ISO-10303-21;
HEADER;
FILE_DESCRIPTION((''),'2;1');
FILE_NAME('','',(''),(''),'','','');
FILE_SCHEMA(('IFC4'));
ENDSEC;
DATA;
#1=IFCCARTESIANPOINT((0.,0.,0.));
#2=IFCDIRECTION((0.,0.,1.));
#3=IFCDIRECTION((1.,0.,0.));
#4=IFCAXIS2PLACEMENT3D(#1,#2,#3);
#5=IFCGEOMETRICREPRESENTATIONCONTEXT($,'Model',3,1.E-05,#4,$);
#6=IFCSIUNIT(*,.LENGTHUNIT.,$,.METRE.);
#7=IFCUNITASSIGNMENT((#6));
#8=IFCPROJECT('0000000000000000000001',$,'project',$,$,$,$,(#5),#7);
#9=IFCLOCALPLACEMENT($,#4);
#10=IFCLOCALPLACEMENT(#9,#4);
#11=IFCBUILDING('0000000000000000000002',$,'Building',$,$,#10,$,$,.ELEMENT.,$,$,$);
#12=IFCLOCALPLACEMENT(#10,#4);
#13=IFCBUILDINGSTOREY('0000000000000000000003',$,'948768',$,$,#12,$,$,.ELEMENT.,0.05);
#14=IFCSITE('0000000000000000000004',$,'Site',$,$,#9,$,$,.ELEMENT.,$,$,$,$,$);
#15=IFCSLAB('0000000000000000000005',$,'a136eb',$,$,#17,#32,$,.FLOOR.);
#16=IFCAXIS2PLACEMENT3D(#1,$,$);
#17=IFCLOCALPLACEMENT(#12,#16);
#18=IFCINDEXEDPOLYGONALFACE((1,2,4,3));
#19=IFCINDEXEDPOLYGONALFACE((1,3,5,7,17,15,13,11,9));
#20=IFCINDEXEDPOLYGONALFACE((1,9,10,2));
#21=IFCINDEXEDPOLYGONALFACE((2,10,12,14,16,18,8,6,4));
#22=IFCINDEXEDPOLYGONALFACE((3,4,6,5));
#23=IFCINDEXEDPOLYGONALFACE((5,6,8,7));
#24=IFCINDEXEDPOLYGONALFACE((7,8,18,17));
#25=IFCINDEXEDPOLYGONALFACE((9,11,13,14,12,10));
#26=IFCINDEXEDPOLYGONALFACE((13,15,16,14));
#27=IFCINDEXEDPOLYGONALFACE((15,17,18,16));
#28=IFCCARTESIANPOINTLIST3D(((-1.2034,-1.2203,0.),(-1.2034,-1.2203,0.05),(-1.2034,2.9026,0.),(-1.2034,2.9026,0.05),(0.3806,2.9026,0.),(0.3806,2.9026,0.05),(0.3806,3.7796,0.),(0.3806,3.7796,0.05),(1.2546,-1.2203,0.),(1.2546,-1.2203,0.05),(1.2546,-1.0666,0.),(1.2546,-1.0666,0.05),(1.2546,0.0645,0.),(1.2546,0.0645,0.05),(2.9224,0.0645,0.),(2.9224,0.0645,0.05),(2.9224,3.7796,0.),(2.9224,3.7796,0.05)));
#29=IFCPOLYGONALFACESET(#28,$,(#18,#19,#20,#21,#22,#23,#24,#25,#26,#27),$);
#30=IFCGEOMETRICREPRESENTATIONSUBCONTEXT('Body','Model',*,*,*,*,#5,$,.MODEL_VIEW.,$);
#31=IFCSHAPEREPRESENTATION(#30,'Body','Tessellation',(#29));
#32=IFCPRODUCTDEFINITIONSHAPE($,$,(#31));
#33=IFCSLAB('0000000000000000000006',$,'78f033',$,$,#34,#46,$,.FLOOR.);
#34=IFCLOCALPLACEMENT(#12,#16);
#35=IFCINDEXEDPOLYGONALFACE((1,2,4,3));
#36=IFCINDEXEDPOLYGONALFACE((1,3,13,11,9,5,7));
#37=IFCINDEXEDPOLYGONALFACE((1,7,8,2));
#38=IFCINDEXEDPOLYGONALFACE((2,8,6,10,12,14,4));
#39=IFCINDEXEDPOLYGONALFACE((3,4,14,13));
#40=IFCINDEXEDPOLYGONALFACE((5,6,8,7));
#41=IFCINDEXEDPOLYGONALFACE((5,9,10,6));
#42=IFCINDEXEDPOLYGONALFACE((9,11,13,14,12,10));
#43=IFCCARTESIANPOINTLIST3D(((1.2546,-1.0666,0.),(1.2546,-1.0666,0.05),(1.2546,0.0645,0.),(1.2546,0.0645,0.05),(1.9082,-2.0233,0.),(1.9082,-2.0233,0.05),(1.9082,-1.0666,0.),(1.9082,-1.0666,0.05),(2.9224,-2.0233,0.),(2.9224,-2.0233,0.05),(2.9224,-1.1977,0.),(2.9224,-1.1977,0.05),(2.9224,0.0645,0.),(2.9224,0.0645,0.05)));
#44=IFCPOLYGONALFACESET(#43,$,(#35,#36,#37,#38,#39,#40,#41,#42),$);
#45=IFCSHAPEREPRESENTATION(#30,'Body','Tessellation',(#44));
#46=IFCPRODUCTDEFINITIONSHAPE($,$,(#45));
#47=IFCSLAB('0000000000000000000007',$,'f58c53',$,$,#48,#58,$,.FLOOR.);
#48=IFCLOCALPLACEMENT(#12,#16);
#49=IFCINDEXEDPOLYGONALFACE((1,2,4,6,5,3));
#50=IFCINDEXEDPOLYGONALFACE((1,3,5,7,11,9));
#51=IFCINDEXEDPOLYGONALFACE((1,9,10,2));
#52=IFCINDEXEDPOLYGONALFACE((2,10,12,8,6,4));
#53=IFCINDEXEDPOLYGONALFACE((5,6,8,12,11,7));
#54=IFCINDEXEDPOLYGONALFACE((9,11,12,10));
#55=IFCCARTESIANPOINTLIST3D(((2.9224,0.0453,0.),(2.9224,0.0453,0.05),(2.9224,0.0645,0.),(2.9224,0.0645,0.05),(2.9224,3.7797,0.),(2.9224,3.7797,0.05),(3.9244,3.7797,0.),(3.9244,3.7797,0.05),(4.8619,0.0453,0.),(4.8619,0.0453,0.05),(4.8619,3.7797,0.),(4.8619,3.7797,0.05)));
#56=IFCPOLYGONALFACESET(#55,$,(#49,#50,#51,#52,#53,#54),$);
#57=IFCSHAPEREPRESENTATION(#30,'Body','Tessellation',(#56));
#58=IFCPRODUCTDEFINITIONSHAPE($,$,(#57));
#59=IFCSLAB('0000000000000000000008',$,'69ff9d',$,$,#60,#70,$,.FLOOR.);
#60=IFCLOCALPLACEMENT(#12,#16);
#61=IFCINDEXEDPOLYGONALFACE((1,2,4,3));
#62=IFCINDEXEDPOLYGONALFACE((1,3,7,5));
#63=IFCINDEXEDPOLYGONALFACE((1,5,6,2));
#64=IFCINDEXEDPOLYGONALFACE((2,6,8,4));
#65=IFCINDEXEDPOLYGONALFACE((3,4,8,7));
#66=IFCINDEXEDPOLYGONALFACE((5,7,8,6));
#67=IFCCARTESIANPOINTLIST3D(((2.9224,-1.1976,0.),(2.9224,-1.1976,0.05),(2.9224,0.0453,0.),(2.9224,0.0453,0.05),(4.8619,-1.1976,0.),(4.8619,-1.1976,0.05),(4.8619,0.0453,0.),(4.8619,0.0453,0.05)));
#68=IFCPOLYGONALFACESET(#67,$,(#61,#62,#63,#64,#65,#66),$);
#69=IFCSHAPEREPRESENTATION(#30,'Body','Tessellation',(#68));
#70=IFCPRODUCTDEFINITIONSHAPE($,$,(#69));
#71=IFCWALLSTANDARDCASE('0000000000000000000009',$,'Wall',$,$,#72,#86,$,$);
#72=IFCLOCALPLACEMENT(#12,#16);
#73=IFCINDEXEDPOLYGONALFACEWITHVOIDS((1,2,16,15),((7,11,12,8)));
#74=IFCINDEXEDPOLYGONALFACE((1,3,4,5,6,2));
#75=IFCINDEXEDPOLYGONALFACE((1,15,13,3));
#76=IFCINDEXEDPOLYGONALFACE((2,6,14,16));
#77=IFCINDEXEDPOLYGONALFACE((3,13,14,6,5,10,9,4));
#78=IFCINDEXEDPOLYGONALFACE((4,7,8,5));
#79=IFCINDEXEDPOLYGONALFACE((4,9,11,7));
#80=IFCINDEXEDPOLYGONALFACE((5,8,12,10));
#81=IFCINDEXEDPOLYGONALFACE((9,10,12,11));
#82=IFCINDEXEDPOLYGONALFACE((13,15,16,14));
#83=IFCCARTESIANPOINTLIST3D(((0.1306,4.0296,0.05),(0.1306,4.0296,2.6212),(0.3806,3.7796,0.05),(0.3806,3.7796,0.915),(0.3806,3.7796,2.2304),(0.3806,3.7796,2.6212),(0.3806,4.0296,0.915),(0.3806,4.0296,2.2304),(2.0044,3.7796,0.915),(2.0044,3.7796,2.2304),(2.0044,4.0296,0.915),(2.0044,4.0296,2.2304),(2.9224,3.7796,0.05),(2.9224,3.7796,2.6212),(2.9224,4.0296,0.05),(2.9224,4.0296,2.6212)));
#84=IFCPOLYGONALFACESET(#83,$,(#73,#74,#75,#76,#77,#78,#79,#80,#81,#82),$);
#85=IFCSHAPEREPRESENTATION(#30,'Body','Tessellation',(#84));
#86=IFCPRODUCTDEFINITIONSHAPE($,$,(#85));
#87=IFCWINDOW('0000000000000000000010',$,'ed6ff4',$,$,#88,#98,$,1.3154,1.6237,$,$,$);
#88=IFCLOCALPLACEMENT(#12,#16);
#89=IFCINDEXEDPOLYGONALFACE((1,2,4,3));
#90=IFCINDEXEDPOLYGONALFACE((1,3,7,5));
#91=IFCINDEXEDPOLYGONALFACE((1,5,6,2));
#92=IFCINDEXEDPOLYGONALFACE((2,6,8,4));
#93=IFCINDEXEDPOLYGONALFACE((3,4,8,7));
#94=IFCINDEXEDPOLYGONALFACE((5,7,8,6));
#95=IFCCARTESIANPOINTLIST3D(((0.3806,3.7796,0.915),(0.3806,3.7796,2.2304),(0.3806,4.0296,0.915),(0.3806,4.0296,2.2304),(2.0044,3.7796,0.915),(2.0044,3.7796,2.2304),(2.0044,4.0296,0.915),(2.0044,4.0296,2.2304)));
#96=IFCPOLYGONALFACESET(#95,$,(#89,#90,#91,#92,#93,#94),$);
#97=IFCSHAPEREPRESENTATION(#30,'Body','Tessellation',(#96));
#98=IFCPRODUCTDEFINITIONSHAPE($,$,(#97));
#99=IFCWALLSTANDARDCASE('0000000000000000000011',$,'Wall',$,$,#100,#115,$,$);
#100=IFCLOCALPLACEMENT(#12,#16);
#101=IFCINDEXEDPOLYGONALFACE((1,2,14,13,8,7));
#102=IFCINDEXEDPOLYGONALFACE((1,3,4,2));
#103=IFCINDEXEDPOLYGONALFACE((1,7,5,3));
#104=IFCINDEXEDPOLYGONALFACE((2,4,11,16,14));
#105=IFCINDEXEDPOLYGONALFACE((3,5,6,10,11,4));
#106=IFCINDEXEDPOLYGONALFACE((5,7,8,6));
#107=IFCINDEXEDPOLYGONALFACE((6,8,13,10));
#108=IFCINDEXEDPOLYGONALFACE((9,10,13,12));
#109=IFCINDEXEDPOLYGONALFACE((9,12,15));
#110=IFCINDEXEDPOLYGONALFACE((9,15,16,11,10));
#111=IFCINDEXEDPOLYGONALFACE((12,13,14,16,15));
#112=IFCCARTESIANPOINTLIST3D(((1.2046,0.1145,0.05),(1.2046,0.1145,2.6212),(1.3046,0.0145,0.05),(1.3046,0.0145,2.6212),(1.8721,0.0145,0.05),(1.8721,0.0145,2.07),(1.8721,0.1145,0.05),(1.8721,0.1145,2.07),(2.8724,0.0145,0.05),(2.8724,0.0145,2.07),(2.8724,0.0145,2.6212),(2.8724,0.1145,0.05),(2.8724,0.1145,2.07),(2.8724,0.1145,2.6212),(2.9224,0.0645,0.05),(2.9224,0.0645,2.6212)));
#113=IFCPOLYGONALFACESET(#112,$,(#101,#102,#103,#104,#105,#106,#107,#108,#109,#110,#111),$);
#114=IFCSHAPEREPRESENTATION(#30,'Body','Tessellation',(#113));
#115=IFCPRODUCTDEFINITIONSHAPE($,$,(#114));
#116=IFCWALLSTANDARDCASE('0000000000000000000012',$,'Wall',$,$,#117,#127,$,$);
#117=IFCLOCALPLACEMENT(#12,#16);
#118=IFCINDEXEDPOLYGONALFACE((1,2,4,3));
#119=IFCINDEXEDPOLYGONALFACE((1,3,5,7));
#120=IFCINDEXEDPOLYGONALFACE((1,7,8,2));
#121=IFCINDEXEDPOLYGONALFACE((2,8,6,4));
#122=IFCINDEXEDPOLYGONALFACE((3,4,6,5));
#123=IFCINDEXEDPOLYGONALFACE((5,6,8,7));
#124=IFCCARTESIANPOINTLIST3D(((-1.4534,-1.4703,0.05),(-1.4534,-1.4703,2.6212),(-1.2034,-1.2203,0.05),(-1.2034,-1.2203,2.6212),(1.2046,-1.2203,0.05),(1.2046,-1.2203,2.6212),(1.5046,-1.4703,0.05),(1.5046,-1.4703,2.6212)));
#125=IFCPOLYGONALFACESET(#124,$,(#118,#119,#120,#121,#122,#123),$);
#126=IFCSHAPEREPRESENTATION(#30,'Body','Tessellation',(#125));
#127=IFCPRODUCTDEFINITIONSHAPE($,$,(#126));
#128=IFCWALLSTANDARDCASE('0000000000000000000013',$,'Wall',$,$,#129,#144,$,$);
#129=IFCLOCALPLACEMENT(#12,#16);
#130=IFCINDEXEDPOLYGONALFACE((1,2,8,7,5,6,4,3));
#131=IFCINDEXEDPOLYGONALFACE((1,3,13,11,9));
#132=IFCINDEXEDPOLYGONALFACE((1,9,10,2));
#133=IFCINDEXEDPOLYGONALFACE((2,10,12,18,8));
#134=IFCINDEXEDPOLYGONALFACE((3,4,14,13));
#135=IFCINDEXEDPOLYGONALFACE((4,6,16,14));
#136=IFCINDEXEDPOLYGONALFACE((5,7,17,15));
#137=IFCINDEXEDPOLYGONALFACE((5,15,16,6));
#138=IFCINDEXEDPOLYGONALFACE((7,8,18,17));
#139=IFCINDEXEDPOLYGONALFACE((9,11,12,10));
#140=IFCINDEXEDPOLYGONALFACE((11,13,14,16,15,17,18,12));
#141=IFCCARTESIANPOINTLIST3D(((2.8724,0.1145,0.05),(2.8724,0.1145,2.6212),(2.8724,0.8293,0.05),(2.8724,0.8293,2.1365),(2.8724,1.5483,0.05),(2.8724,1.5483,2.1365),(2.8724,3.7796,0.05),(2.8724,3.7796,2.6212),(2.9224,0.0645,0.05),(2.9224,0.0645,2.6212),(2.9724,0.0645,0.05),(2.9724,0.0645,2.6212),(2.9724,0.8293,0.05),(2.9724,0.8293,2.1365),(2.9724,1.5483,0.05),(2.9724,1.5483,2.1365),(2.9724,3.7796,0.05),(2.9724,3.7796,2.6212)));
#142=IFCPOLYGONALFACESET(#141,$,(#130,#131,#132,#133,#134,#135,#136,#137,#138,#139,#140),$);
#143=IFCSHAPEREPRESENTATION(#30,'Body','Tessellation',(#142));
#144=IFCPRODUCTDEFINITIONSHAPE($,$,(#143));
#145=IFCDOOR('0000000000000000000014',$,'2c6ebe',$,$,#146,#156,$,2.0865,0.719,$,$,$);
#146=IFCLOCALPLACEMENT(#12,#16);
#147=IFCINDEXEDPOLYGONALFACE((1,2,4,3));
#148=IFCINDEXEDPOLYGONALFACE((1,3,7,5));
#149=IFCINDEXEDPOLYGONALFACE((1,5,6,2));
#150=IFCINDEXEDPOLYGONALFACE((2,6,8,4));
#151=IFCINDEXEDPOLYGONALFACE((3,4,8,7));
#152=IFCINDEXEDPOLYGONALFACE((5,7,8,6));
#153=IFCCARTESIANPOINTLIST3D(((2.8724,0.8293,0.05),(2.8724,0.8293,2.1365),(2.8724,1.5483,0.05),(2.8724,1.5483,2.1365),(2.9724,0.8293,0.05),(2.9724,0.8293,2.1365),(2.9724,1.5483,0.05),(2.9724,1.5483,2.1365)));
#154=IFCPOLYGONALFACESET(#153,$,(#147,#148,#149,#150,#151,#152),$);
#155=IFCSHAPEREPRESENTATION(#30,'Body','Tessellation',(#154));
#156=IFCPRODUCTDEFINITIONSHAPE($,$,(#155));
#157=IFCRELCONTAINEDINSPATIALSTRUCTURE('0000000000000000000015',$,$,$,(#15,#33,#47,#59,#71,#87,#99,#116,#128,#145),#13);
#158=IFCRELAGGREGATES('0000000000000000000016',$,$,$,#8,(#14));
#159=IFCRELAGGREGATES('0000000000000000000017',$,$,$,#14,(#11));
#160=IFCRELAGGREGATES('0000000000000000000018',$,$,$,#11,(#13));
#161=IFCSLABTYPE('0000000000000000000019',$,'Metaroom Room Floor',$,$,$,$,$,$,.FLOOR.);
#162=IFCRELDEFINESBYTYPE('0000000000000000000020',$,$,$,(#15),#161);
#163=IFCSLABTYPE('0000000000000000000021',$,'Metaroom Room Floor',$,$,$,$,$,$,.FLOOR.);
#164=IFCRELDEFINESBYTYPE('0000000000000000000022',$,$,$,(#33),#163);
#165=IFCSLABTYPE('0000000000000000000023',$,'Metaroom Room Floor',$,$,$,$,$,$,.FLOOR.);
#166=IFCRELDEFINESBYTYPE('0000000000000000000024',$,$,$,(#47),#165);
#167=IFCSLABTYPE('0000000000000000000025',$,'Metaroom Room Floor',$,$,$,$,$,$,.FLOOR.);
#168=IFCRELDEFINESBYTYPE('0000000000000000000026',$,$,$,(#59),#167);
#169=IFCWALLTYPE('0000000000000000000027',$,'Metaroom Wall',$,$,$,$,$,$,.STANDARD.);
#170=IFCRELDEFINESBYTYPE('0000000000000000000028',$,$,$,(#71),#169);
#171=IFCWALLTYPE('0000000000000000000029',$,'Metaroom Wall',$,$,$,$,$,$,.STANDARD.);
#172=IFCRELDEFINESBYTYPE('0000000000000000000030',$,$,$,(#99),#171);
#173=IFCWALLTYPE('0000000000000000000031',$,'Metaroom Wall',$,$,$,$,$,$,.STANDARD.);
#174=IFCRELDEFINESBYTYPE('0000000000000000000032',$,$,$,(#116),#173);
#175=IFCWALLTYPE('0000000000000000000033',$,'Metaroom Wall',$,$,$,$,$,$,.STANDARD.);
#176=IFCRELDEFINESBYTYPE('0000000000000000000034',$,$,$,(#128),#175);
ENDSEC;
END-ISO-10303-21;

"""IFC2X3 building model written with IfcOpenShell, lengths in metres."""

from ifc_helpers import new_model, si_unit, frame, origin_with_axes, place, context, subcontext, project, spatial, polyline, outline, extrude, type_object, element, fill, save


model = new_model("IFC2X3")

# Units and contexts
model_context = context("Model", 3, precision=1e-05, world=origin_with_axes())
body_context = subcontext(model_context, "Body", "Model", "MODEL_VIEW")
ifc_project = project(units=[si_unit("LENGTHUNIT", "METRE")], contexts=[model_context])

# Site, building, storey
site_placement = place(None, origin_with_axes())
site = spatial("IfcSite", under=ifc_project, at=site_placement, Name="Site", CompositionType="ELEMENT")
building_placement = place(site_placement, origin_with_axes())
building = spatial("IfcBuilding", under=site, at=building_placement, Name="Building", CompositionType="ELEMENT")
storey_placement = place(building_placement, frame((0.0, 0.0, 0.0), z_axis=(0.0, 0.0, 1.0), x_axis=(1.0, 0.0, 0.0)))
storey = spatial("IfcBuildingStorey", under=building, at=storey_placement, Name="948768", CompositionType="ELEMENT", Elevation=0.05)

# Slabs
slab_type_1 = type_object("IfcSlabType", Name="Metaroom Room Floor", PredefinedType="FLOOR")
slab_1_placement = place(storey_placement, frame((2.9224, 3.7796, 0.05), z_axis=(0.0, 0.0, 1.0), x_axis=(1.0, 0.0, 0.0)))
element("IfcSlab", 1, at=slab_1_placement, inside=storey, type_object=slab_type_1, Name="a136eb", PredefinedType="FLOOR", context=body_context, shape_type="SweptSolid", body=[
    extrude(outline(polyline([(0.0, 0.0), (0.0, -3.7152), (-1.6678, -3.7152), (-1.6678, -4.8463), (-1.6678, -5.0), (-4.1257, -5.0), (-4.1257, -0.877), (-2.5417, -0.877), (-2.5417, 0.0), (0.0, 0.0)])), origin_with_axes(), (0.0, 0.0, -1.0), 0.05),
])
slab_type_2 = type_object("IfcSlabType", Name="Metaroom Room Floor", PredefinedType="FLOOR")
slab_2_placement = place(storey_placement, frame((1.2546, -1.0666, 0.05), z_axis=(0.0, 0.0, 1.0), x_axis=(1.0, 0.0, 0.0)))
element("IfcSlab", 2, at=slab_2_placement, inside=storey, type_object=slab_type_2, Name="78f033", PredefinedType="FLOOR", context=body_context, shape_type="SweptSolid", body=[
    extrude(outline(polyline([(0.0, 0.0), (0.0, 1.1311), (1.6678, 1.1311), (1.6678, -0.1311), (1.6678, -0.9567), (0.6536, -0.9567), (0.6536, 0.0), (0.0, 0.0)])), origin_with_axes(), (0.0, 0.0, -1.0), 0.05),
])
slab_type_3 = type_object("IfcSlabType", Name="Metaroom Room Floor", PredefinedType="FLOOR")
slab_3_placement = place(storey_placement, frame((4.8619, 3.7797, 0.05), z_axis=(0.0, 0.0, 1.0), x_axis=(1.0, 0.0, 0.0)))
element("IfcSlab", 3, at=slab_3_placement, inside=storey, type_object=slab_type_3, Name="f58c53", PredefinedType="FLOOR", context=body_context, shape_type="SweptSolid", body=[
    extrude(outline(polyline([(0.0, 0.0), (-0.9375, 0.0), (-1.9395, 0.0), (-1.9395, -3.7152), (-1.9395, -3.7344), (0.0, -3.7344), (0.0, 0.0)])), origin_with_axes(), (0.0, 0.0, -1.0), 0.05),
])
slab_type_4 = type_object("IfcSlabType", Name="Metaroom Room Floor", PredefinedType="FLOOR")
slab_4_placement = place(storey_placement, frame((2.9224, -1.1976, 0.05), z_axis=(0.0, 0.0, 1.0), x_axis=(1.0, 0.0, 0.0)))
element("IfcSlab", 4, at=slab_4_placement, inside=storey, type_object=slab_type_4, Name="69ff9d", PredefinedType="FLOOR", context=body_context, shape_type="SweptSolid", body=[
    extrude(outline(polyline([(0.0, 0.0), (1.9395, 0.0), (1.9395, 1.2429), (0.0, 1.2429), (0.0, 0.0)])), origin_with_axes(), (0.0, 0.0, -1.0), 0.05),
])

# Wall, opening, window
wall_type_1 = type_object("IfcWallType", Name="Metaroom Wall", PredefinedType="STANDARD")
wall_1_placement = place(storey_placement, frame((0.1306, 4.0296, 0.05), z_axis=(0.0, 0.0, 1.0), x_axis=(1.0, 0.0, 0.0)))
wall_1 = element("IfcWallStandardCase", 5, at=wall_1_placement, inside=storey, type_object=wall_type_1, Name="Wall", context=body_context, shape_type="SweptSolid", body=[
    extrude(outline(polyline([(0.0, 0.0), (2.7917, 0.0), (2.7917, -0.25), (2.7417, -0.25), (0.25, -0.25), (0.0, 0.0)])), origin_with_axes(), (0.0, 0.0, 1.0), 2.5712),
])
opening_1_placement = place(wall_1_placement, frame((0.25, -0.25, 0.865), z_axis=(0.0, 0.0, 1.0), x_axis=(1.0, 0.0, 0.0)))
opening_1 = element("IfcOpeningElement", 6, at=opening_1_placement, cuts=wall_1, ObjectType="OPENING", context=body_context, shape_type="SweptSolid", body=[
    extrude(outline(polyline([(0.0, 0.0), (1.6237, 0.0), (1.6237, 1.3154), (0.0, 1.3154), (0.0, 0.0)])), frame((0.0, 0.0, 0.0), z_axis=(0.0, -1.0, 0.0), x_axis=(1.0, 0.0, 0.0)), (0.0, 0.0, -1.0), 0.2501),
])
window_1_placement = place(opening_1_placement, origin_with_axes())
window_1 = element("IfcWindow", 7, at=window_1_placement, inside=storey, Name="ed6ff4", OverallHeight=1.3154, OverallWidth=1.6237, context=body_context, shape_type="SweptSolid", body=[
    extrude(outline(polyline([(0.0, 0.0), (-1.6237, 0.0), (-1.6237, 1.3154), (0.0, 1.3154), (0.0, 0.0)])), frame((0.0, 0.25, 0.0), z_axis=(0.0, 1.0, 0.0), x_axis=(-1.0, 0.0, 0.0)), (0.0, 0.0, -1.0), 0.25),
])
fill(opening_1, window_1)

# Wall, opening
wall_type_2 = type_object("IfcWallType", Name="Metaroom Wall", PredefinedType="STANDARD")
wall_2_placement = place(storey_placement, frame((2.8724, 0.1145, 0.05), z_axis=(0.0, 0.0, 1.0), x_axis=(1.0, 0.0, 0.0)))
wall_2 = element("IfcWallStandardCase", 8, at=wall_2_placement, inside=storey, type_object=wall_type_2, Name="Wall", context=body_context, shape_type="SweptSolid", body=[
    extrude(outline(polyline([(0.0, 0.0), (0.05, -0.05), (0.0, -0.1), (-1.5678, -0.1), (-1.6678, 0.0), (0.0, 0.0)])), origin_with_axes(), (0.0, 0.0, 1.0), 2.5712),
])
opening_2_placement = place(wall_2_placement, frame((0.0, 0.0, 0.0), z_axis=(0.0, 0.0, 1.0), x_axis=(-1.0, 0.0, 0.0)))
element("IfcOpeningElement", 9, at=opening_2_placement, cuts=wall_2, ObjectType="OPENING", context=body_context, shape_type="SweptSolid", body=[
    extrude(outline(polyline([(0.0, 0.0), (1.0003, 0.0), (1.0003, 2.02), (0.0, 2.02), (0.0, 0.0)])), frame((0.0, 0.0, 0.0), z_axis=(0.0, -1.0, 0.0), x_axis=(1.0, 0.0, 0.0)), (0.0, 0.0, -1.0), 0.1001),
])

# Wall
wall_type_3 = type_object("IfcWallType", Name="Metaroom Wall", PredefinedType="STANDARD")
wall_3_placement = place(storey_placement, frame((-1.2034, -1.2203, 0.05), z_axis=(0.0, 0.0, 1.0), x_axis=(1.0, 0.0, 0.0)))
element("IfcWallStandardCase", 10, at=wall_3_placement, inside=storey, type_object=wall_type_3, Name="Wall", context=body_context, shape_type="SweptSolid", body=[
    extrude(outline(polyline([(0.0, 0.0), (2.408, 0.0), (2.708, -0.25), (-0.25, -0.25), (0.0, 0.0)])), origin_with_axes(), (0.0, 0.0, 1.0), 2.5712),
])

# Wall, opening, door
wall_type_4 = type_object("IfcWallType", Name="Metaroom Wall", PredefinedType="STANDARD")
wall_4_placement = place(storey_placement, frame((2.8724, 3.7796, 0.05), z_axis=(0.0, 0.0, 1.0), x_axis=(1.0, 0.0, 0.0)))
wall_4 = element("IfcWallStandardCase", 11, at=wall_4_placement, inside=storey, type_object=wall_type_4, Name="Wall", context=body_context, shape_type="SweptSolid", body=[
    extrude(outline(polyline([(0.0, 0.0), (0.05, 0.0), (0.1, 0.0), (0.1, -3.7152), (0.05, -3.7152), (0.0, -3.6652), (0.0, 0.0)])), origin_with_axes(), (0.0, 0.0, 1.0), 2.5712),
])
opening_3_placement = place(wall_4_placement, frame((0.0, -2.2314, 0.0), z_axis=(0.0, 0.0, 1.0), x_axis=(0.0, -1.0, 0.0)))
opening_3 = element("IfcOpeningElement", 12, at=opening_3_placement, cuts=wall_4, ObjectType="OPENING", context=body_context, shape_type="SweptSolid", body=[
    extrude(outline(polyline([(0.0, 0.0), (0.719, 0.0), (0.719, 2.0865), (0.0, 2.0865), (0.0, 0.0)])), frame((0.0, 0.0, 0.0), z_axis=(0.0, -1.0, 0.0), x_axis=(1.0, 0.0, 0.0)), (0.0, 0.0, -1.0), 0.1001),
])
door_1_placement = place(opening_3_placement, origin_with_axes())
door_1 = element("IfcDoor", 13, at=door_1_placement, inside=storey, Name="2c6ebe", OverallHeight=2.0865, OverallWidth=0.719, context=body_context, shape_type="SweptSolid", body=[
    extrude(outline(polyline([(0.0, 0.0), (-0.719, 0.0), (-0.719, 2.0865), (0.0, 2.0865), (0.0, 0.0)])), frame((0.0, 0.1, 0.0), z_axis=(0.0, 1.0, 0.0), x_axis=(-1.0, 0.0, 0.0)), (0.0, 0.0, -1.0), 0.1),
])
fill(opening_3, door_1)

save(model, "model.ifc")
